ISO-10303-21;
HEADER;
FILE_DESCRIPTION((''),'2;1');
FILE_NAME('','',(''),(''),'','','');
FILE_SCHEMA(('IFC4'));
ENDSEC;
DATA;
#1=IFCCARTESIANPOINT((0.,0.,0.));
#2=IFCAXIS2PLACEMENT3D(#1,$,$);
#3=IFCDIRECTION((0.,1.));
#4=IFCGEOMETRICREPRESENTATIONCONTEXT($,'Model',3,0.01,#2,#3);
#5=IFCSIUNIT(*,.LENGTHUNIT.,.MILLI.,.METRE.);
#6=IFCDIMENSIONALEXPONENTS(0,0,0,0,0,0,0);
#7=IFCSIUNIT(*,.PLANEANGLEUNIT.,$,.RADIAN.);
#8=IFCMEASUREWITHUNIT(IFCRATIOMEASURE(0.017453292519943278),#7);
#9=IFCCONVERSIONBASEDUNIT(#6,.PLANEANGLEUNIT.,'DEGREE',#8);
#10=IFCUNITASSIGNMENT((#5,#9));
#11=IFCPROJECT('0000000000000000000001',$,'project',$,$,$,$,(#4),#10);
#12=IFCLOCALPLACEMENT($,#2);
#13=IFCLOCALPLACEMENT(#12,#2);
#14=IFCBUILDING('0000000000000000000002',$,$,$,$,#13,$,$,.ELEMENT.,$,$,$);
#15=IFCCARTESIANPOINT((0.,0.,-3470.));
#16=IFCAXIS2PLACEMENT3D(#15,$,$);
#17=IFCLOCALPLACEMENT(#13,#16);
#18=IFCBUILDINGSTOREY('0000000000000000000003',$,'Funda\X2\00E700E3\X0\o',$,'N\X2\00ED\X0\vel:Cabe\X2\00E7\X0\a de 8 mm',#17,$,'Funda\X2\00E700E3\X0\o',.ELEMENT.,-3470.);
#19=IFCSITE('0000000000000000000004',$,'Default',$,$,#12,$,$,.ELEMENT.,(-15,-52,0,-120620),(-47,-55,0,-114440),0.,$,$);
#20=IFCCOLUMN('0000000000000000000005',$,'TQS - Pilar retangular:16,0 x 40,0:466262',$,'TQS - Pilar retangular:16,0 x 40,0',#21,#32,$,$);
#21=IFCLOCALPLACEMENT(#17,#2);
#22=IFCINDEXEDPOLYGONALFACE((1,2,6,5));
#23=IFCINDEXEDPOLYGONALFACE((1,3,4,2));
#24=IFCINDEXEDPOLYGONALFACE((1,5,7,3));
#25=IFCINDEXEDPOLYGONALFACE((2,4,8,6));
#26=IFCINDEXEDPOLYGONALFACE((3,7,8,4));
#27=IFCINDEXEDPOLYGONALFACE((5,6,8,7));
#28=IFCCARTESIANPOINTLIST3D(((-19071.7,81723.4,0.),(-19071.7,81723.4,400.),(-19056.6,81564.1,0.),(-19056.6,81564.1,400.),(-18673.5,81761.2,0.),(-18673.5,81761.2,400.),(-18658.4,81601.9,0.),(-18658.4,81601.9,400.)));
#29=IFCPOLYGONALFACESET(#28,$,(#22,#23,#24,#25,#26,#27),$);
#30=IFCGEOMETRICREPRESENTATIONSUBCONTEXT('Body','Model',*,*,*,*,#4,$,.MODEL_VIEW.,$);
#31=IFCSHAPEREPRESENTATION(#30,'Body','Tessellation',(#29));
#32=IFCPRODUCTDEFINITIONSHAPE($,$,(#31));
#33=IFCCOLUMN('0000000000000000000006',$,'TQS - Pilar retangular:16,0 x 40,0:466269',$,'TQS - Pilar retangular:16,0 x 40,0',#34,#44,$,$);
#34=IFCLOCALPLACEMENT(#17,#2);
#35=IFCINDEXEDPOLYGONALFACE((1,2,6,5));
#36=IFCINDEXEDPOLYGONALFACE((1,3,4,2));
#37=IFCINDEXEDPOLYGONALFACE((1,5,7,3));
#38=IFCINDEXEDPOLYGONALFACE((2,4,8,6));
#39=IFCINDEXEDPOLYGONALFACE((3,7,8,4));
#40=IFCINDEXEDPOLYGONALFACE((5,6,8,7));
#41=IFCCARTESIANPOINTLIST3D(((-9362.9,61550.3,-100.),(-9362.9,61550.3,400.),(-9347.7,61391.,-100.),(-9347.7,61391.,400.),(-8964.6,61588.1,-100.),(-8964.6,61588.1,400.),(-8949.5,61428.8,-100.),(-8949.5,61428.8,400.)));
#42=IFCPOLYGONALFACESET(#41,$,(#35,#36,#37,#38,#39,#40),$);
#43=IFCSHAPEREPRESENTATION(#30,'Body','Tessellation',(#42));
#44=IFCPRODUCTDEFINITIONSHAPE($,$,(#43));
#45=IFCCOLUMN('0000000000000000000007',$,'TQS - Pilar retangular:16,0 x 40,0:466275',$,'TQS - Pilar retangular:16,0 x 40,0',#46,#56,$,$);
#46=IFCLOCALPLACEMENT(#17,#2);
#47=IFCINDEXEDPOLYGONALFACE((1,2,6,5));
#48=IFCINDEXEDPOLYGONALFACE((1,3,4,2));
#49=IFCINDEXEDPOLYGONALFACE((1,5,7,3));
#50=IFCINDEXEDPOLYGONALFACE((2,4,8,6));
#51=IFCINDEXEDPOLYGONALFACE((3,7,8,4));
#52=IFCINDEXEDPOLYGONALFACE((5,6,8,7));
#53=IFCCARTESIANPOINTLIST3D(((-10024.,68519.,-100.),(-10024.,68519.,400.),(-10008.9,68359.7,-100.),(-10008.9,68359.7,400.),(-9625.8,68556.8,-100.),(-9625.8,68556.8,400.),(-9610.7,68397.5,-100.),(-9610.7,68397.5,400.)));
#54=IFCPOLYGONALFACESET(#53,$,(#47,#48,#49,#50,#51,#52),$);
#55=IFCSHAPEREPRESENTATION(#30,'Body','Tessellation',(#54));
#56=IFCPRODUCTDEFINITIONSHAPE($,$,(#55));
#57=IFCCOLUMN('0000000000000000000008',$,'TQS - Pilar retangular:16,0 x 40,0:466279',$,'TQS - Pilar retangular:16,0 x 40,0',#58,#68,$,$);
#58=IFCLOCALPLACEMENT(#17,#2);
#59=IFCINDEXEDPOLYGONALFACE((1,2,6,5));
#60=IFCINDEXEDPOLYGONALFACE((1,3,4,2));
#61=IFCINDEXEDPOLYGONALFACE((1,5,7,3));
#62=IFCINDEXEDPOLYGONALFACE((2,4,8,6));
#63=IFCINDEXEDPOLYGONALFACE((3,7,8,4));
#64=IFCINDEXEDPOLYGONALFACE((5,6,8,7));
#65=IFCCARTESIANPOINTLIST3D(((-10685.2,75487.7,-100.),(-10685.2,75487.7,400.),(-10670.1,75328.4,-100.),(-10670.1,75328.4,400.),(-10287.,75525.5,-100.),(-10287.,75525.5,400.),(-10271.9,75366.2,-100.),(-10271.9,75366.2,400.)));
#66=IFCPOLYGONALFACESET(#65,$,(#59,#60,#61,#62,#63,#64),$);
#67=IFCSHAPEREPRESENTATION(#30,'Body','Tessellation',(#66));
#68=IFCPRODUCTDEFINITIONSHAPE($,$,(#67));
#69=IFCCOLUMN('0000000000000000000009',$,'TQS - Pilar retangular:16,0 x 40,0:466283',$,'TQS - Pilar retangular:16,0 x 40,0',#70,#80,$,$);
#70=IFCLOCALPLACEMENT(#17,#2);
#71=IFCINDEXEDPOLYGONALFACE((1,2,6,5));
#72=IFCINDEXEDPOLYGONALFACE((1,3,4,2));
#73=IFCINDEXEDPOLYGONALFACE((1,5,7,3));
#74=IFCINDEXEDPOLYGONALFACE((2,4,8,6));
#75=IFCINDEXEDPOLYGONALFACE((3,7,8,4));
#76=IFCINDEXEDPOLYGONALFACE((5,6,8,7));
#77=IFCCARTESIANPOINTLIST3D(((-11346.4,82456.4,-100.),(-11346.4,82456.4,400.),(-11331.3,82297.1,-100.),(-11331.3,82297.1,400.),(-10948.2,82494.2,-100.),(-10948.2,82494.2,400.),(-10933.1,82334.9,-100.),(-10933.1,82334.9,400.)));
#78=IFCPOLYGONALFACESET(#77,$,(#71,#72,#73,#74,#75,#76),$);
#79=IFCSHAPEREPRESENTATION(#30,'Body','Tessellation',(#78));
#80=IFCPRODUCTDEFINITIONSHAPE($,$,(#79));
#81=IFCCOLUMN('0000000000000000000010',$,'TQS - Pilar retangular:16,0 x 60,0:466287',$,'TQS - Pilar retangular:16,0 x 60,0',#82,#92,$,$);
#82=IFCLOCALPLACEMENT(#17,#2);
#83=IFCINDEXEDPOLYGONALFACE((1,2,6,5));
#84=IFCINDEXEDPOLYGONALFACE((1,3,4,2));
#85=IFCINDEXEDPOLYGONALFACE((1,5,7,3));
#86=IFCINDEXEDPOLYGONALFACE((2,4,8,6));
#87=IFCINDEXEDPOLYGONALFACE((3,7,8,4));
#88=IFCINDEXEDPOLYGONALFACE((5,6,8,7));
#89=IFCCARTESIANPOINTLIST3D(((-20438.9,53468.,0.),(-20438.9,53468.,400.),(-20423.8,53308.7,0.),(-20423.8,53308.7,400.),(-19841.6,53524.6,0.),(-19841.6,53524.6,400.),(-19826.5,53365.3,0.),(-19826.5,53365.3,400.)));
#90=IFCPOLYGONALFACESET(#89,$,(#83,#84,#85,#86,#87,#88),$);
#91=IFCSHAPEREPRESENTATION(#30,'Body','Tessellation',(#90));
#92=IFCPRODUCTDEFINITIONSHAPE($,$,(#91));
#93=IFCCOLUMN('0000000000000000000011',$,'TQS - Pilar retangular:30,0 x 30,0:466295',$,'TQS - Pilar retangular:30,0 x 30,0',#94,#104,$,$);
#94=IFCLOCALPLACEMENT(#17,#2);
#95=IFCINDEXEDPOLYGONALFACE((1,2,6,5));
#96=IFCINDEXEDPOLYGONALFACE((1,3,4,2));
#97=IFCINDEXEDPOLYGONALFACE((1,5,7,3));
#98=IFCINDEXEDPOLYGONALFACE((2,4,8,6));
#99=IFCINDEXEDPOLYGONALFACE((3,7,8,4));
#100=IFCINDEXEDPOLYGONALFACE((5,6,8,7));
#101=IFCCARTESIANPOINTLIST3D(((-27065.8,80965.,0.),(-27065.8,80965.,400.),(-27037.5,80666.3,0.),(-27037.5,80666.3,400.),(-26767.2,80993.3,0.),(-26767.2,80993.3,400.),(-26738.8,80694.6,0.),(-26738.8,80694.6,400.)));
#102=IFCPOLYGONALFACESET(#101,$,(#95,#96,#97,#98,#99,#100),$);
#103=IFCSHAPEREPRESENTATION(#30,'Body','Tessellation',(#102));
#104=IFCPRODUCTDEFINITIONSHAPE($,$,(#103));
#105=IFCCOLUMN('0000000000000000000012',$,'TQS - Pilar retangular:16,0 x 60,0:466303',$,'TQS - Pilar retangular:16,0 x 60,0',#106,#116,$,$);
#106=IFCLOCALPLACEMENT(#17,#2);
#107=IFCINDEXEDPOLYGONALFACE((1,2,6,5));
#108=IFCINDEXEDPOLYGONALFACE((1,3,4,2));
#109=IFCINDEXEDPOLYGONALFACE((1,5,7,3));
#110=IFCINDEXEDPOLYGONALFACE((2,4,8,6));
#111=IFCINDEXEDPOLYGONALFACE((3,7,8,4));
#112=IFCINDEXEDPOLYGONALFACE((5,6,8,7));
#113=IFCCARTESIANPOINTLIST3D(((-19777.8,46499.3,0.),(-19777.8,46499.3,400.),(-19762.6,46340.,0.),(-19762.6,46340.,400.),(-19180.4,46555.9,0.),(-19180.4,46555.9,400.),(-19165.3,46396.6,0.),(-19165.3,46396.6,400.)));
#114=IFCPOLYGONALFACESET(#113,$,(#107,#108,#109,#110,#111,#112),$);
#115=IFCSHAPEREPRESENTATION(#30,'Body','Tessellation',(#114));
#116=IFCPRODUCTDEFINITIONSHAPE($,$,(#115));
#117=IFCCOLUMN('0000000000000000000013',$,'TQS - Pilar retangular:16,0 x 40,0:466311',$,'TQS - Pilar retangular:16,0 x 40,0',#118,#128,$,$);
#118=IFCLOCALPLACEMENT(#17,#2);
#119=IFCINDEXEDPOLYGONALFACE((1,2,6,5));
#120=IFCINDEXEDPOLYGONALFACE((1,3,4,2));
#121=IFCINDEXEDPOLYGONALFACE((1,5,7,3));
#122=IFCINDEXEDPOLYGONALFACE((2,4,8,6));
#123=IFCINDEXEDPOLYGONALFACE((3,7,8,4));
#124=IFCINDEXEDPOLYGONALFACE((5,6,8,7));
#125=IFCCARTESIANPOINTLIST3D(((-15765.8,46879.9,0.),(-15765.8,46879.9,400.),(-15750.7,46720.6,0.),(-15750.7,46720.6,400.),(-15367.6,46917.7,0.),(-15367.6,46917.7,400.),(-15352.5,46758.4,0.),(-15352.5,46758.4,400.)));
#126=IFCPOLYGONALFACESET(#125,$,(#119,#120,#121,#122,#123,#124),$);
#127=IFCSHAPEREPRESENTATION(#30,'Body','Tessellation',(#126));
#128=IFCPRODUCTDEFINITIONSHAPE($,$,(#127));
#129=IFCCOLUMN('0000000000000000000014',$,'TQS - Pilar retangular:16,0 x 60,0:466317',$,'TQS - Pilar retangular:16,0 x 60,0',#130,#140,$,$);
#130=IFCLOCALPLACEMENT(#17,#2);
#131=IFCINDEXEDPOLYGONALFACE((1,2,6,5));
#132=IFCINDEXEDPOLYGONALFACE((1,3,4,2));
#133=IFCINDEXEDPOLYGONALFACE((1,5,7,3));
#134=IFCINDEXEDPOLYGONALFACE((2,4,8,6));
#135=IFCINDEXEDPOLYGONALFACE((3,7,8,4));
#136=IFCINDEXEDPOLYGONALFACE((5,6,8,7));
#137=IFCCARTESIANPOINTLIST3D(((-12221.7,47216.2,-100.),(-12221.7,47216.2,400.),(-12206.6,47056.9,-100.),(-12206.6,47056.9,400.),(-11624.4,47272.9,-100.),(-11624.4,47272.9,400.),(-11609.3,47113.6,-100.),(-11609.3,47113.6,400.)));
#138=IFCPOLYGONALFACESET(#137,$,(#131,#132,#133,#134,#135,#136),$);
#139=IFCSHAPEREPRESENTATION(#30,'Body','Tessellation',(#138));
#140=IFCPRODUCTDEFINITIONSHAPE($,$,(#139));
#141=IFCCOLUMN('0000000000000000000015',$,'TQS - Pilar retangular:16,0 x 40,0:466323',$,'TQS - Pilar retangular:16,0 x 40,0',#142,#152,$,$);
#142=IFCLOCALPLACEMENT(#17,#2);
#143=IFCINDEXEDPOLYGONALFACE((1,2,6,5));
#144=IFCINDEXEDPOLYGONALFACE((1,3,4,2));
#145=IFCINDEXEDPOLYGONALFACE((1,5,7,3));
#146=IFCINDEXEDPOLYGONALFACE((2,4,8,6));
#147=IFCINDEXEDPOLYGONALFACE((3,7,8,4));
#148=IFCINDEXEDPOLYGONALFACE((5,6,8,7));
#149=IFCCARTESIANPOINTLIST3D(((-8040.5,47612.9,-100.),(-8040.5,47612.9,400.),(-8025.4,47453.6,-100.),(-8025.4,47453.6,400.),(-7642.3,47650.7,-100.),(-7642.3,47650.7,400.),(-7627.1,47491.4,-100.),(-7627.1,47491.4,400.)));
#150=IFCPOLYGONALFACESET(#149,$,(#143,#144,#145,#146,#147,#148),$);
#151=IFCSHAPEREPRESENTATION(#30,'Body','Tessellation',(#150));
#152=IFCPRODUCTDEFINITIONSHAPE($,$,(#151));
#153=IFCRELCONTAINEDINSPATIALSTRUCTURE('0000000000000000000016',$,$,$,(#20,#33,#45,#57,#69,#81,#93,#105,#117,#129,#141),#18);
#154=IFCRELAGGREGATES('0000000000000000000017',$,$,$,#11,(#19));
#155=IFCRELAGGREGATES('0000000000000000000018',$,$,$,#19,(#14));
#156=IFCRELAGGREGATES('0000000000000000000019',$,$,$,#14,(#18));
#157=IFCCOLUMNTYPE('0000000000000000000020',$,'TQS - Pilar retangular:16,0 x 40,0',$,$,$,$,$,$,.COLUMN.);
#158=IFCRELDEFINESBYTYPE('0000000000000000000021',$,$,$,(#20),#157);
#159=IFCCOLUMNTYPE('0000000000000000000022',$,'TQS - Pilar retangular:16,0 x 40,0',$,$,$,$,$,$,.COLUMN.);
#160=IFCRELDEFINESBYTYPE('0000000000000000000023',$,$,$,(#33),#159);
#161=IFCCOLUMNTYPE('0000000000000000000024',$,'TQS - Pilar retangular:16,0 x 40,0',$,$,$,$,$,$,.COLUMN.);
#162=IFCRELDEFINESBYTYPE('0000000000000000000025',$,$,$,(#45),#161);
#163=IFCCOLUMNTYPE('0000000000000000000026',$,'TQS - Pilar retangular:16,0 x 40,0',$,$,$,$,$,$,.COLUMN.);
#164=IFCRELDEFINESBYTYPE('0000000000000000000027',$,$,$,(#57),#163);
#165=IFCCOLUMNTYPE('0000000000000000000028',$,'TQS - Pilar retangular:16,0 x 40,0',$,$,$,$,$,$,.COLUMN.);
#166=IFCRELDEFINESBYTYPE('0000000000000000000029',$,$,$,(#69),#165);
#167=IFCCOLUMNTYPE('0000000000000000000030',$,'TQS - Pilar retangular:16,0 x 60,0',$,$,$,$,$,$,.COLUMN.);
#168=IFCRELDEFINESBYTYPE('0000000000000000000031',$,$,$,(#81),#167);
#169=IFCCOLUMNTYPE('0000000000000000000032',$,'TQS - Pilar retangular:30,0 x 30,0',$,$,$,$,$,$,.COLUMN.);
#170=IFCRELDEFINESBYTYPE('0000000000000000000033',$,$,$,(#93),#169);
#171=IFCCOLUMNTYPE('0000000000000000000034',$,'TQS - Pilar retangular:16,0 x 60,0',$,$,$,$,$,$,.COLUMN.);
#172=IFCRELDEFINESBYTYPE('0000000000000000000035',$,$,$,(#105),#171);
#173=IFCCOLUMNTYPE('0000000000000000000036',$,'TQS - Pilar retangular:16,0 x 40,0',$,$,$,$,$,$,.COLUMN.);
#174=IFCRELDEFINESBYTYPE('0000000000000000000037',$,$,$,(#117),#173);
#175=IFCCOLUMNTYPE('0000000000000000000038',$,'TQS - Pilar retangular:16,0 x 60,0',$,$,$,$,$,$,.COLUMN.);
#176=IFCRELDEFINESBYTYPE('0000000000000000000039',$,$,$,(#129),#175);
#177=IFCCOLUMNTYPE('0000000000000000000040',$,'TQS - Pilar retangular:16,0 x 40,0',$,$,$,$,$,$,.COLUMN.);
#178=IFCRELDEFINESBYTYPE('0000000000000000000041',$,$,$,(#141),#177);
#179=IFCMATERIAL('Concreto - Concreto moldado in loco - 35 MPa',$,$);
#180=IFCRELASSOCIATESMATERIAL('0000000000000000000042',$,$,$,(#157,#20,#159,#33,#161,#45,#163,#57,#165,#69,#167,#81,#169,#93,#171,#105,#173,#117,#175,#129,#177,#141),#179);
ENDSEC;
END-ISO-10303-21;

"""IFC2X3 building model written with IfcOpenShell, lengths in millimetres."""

from ifc_helpers import new_model, entity, si_unit, converted_unit, direction, frame, frame_2d, origin, origin_2d_with_axis, place, context, subcontext, project, spatial, rectangle, extrude, source, transform, mapped, material, type_object, type_shapes, element, save


model = new_model("IFC2X3")

# Units and contexts
model_context = context("Model", 3, precision=0.01, world=origin(), true_north=direction((0.0, 1.0)))
body_context = subcontext(model_context, "Body", "Model", "MODEL_VIEW")
ifc_project = project(units=[si_unit("LENGTHUNIT", "METRE", prefix="MILLI"), converted_unit("PLANEANGLEUNIT", "DEGREE", entity("IfcRatioMeasure", 0.017453292519943278), si_unit("PLANEANGLEUNIT", "RADIAN"), dimensions=[0, 0, 0, 0, 0, 0, 0])], contexts=[model_context])

# Site, building, storey
site_placement = place(None, origin())
site = spatial("IfcSite", under=ifc_project, at=site_placement, Name="Default", CompositionType="ELEMENT", RefLatitude=(-15, -52, 0, -120620), RefLongitude=(-47, -55, 0, -114440), RefElevation=0.0)
building_placement = place(site_placement, origin())
building = spatial("IfcBuilding", under=site, at=building_placement, CompositionType="ELEMENT")
storey_placement = place(building_placement, frame((0.0, 0.0, -3470.0)))
storey = spatial("IfcBuildingStorey", under=building, at=storey_placement, Name="Fundação", ObjectType="Nível:Cabeça de 8 mm", LongName="Fundação", CompositionType="ELEMENT", Elevation=-3470.0)

# Columns
ifc_material_1 = material(Name="Concreto - Concreto moldado in loco - 35 MPa")
column_type_1 = type_object("IfcColumnType", Name="TQS - Pilar retangular:16,0 x 40,0", PredefinedType="COLUMN", material=ifc_material_1)
shared_shape_1 = source(origin(), body_context, "Body", "SweptSolid", [
    extrude(rectangle(XDim=400.0, YDim=160.0, at=origin_2d_with_axis()), frame((-18865.1, 81662.7, -3470.0), z_axis=(0.0, 0.0, 1.0), x_axis=(-0.995529, -0.094456, 0.0)), (0.0, 0.0, 1.0), 400.0),
])
type_shapes(column_type_1, [shared_shape_1])
column_1_placement = place(storey_placement, frame((0.0, 0.0, 3470.0)))
element("IfcColumn", 1, at=column_1_placement, inside=storey, type_object=column_type_1, material=ifc_material_1, Name="TQS - Pilar retangular:16,0 x 40,0:466262", ObjectType="TQS - Pilar retangular:16,0 x 40,0", context=body_context, shape_type="MappedRepresentation", body=[
    mapped(shared_shape_1, transform((0.0, 0.0, 0.0), scale=1.0)),
])
column_type_2 = type_object("IfcColumnType", Name="TQS - Pilar retangular:16,0 x 40,0", PredefinedType="COLUMN", material=ifc_material_1)
shared_shape_2 = source(origin(), body_context, "Body", "SweptSolid", [
    extrude(rectangle(XDim=400.0, YDim=160.0, at=origin_2d_with_axis()), frame((-9156.2, 61489.5, -3570.0), z_axis=(0.0, 0.0, 1.0), x_axis=(-0.995529, -0.094456, 0.0)), (0.0, 0.0, 1.0), 500.0),
])
type_shapes(column_type_2, [shared_shape_2])
column_2_placement = place(storey_placement, frame((0.0, 0.0, 3470.0)))
element("IfcColumn", 2, at=column_2_placement, inside=storey, type_object=column_type_2, material=ifc_material_1, Name="TQS - Pilar retangular:16,0 x 40,0:466269", ObjectType="TQS - Pilar retangular:16,0 x 40,0", context=body_context, shape_type="MappedRepresentation", body=[
    mapped(shared_shape_2, transform((0.0, 0.0, 0.0), scale=1.0)),
])
column_type_3 = type_object("IfcColumnType", Name="TQS - Pilar retangular:16,0 x 40,0", PredefinedType="COLUMN", material=ifc_material_1)
shared_shape_3 = source(origin(), body_context, "Body", "SweptSolid", [
    extrude(rectangle(XDim=400.0, YDim=160.0, at=frame_2d((0.0, 0.0), x_axis=(1.0, 0.0))), frame((-9817.4, 68458.3, -3570.0), z_axis=(0.0, 0.0, 1.0), x_axis=(-0.995529, -0.094456, 0.0)), (0.0, 0.0, 1.0), 500.0),
])
type_shapes(column_type_3, [shared_shape_3])
column_3_placement = place(storey_placement, frame((0.0, 0.0, 3470.0)))
element("IfcColumn", 3, at=column_3_placement, inside=storey, type_object=column_type_3, material=ifc_material_1, Name="TQS - Pilar retangular:16,0 x 40,0:466275", ObjectType="TQS - Pilar retangular:16,0 x 40,0", context=body_context, shape_type="MappedRepresentation", body=[
    mapped(shared_shape_3, transform((0.0, 0.0, 0.0), scale=1.0)),
])
column_type_4 = type_object("IfcColumnType", Name="TQS - Pilar retangular:16,0 x 40,0", PredefinedType="COLUMN", material=ifc_material_1)
shared_shape_4 = source(origin(), body_context, "Body", "SweptSolid", [
    extrude(rectangle(XDim=400.0, YDim=160.0, at=origin_2d_with_axis()), frame((-10478.6, 75427.0, -3570.0), z_axis=(0.0, 0.0, 1.0), x_axis=(-0.995529, -0.094456, 0.0)), (0.0, 0.0, 1.0), 500.0),
])
type_shapes(column_type_4, [shared_shape_4])
column_4_placement = place(storey_placement, frame((0.0, 0.0, 3470.0)))
element("IfcColumn", 4, at=column_4_placement, inside=storey, type_object=column_type_4, material=ifc_material_1, Name="TQS - Pilar retangular:16,0 x 40,0:466279", ObjectType="TQS - Pilar retangular:16,0 x 40,0", context=body_context, shape_type="MappedRepresentation", body=[
    mapped(shared_shape_4, transform((0.0, 0.0, 0.0), scale=1.0)),
])
column_type_5 = type_object("IfcColumnType", Name="TQS - Pilar retangular:16,0 x 40,0", PredefinedType="COLUMN", material=ifc_material_1)
shared_shape_5 = source(origin(), body_context, "Body", "SweptSolid", [
    extrude(rectangle(XDim=400.0, YDim=160.0, at=origin_2d_with_axis()), frame((-11139.8, 82395.7, -3570.0), z_axis=(0.0, 0.0, 1.0), x_axis=(-0.995529, -0.094456, 0.0)), (0.0, 0.0, 1.0), 500.0),
])
type_shapes(column_type_5, [shared_shape_5])
column_5_placement = place(storey_placement, frame((0.0, 0.0, 3470.0)))
element("IfcColumn", 5, at=column_5_placement, inside=storey, type_object=column_type_5, material=ifc_material_1, Name="TQS - Pilar retangular:16,0 x 40,0:466283", ObjectType="TQS - Pilar retangular:16,0 x 40,0", context=body_context, shape_type="MappedRepresentation", body=[
    mapped(shared_shape_5, transform((0.0, 0.0, 0.0), scale=1.0)),
])
column_type_6 = type_object("IfcColumnType", Name="TQS - Pilar retangular:16,0 x 60,0", PredefinedType="COLUMN", material=ifc_material_1)
shared_shape_6 = source(origin(), body_context, "Body", "SweptSolid", [
    extrude(rectangle(XDim=600.0, YDim=160.0, at=origin_2d_with_axis()), frame((-20132.7, 53416.7, -3470.0), z_axis=(0.0, 0.0, 1.0), x_axis=(-0.995529, -0.094456, 0.0)), (0.0, 0.0, 1.0), 400.0),
])
type_shapes(column_type_6, [shared_shape_6])
column_6_placement = place(storey_placement, frame((0.0, 0.0, 3470.0)))
element("IfcColumn", 6, at=column_6_placement, inside=storey, type_object=column_type_6, material=ifc_material_1, Name="TQS - Pilar retangular:16,0 x 60,0:466287", ObjectType="TQS - Pilar retangular:16,0 x 60,0", context=body_context, shape_type="MappedRepresentation", body=[
    mapped(shared_shape_6, transform((0.0, 0.0, 0.0), scale=1.0)),
])
column_type_7 = type_object("IfcColumnType", Name="TQS - Pilar retangular:30,0 x 30,0", PredefinedType="COLUMN", material=ifc_material_1)
shared_shape_7 = source(origin(), body_context, "Body", "SweptSolid", [
    extrude(rectangle(XDim=300.0, YDim=300.0, at=origin_2d_with_axis()), frame((-26902.3, 80829.8, -3470.0), z_axis=(0.0, 0.0, 1.0), x_axis=(-0.995529, -0.094456, 0.0)), (0.0, 0.0, 1.0), 400.0),
])
type_shapes(column_type_7, [shared_shape_7])
column_7_placement = place(storey_placement, frame((0.0, 0.0, 3470.0)))
element("IfcColumn", 7, at=column_7_placement, inside=storey, type_object=column_type_7, material=ifc_material_1, Name="TQS - Pilar retangular:30,0 x 30,0:466295", ObjectType="TQS - Pilar retangular:30,0 x 30,0", context=body_context, shape_type="MappedRepresentation", body=[
    mapped(shared_shape_7, transform((0.0, 0.0, 0.0), scale=1.0)),
])
column_type_8 = type_object("IfcColumnType", Name="TQS - Pilar retangular:16,0 x 60,0", PredefinedType="COLUMN", material=ifc_material_1)
shared_shape_8 = source(origin(), body_context, "Body", "SweptSolid", [
    extrude(rectangle(XDim=600.0, YDim=160.0, at=origin_2d_with_axis()), frame((-19471.5, 46448.0, -3470.0), z_axis=(0.0, 0.0, 1.0), x_axis=(-0.995529, -0.094456, 0.0)), (0.0, 0.0, 1.0), 400.0),
])
type_shapes(column_type_8, [shared_shape_8])
column_8_placement = place(storey_placement, frame((0.0, 0.0, 3470.0)))
element("IfcColumn", 8, at=column_8_placement, inside=storey, type_object=column_type_8, material=ifc_material_1, Name="TQS - Pilar retangular:16,0 x 60,0:466303", ObjectType="TQS - Pilar retangular:16,0 x 60,0", context=body_context, shape_type="MappedRepresentation", body=[
    mapped(shared_shape_8, transform((0.0, 0.0, 0.0), scale=1.0)),
])
column_type_9 = type_object("IfcColumnType", Name="TQS - Pilar retangular:16,0 x 40,0", PredefinedType="COLUMN", material=ifc_material_1)
shared_shape_9 = source(origin(), body_context, "Body", "SweptSolid", [
    extrude(rectangle(XDim=400.0, YDim=160.0, at=frame_2d((0.0, 0.0), x_axis=(1.0, 0.0))), frame((-15559.1, 46819.2, -3470.0), z_axis=(0.0, 0.0, 1.0), x_axis=(-0.995529, -0.094456, 0.0)), (0.0, 0.0, 1.0), 400.0),
])
type_shapes(column_type_9, [shared_shape_9])
column_9_placement = place(storey_placement, frame((0.0, 0.0, 3470.0)))
element("IfcColumn", 9, at=column_9_placement, inside=storey, type_object=column_type_9, material=ifc_material_1, Name="TQS - Pilar retangular:16,0 x 40,0:466311", ObjectType="TQS - Pilar retangular:16,0 x 40,0", context=body_context, shape_type="MappedRepresentation", body=[
    mapped(shared_shape_9, transform((0.0, 0.0, 0.0), scale=1.0)),
])
column_type_10 = type_object("IfcColumnType", Name="TQS - Pilar retangular:16,0 x 60,0", PredefinedType="COLUMN", material=ifc_material_1)
shared_shape_10 = source(origin(), body_context, "Body", "SweptSolid", [
    extrude(rectangle(XDim=600.0, YDim=160.0, at=frame_2d((0.0, 0.0), x_axis=(1.0, 0.0))), frame((-11915.5, 47164.9, -3570.0), z_axis=(0.0, 0.0, 1.0), x_axis=(-0.995529, -0.094456, 0.0)), (0.0, 0.0, 1.0), 500.0),
])
type_shapes(column_type_10, [shared_shape_10])
column_10_placement = place(storey_placement, frame((0.0, 0.0, 3470.0)))
element("IfcColumn", 10, at=column_10_placement, inside=storey, type_object=column_type_10, material=ifc_material_1, Name="TQS - Pilar retangular:16,0 x 60,0:466317", ObjectType="TQS - Pilar retangular:16,0 x 60,0", context=body_context, shape_type="MappedRepresentation", body=[
    mapped(shared_shape_10, transform((0.0, 0.0, 0.0), scale=1.0)),
])
column_type_11 = type_object("IfcColumnType", Name="TQS - Pilar retangular:16,0 x 40,0", PredefinedType="COLUMN", material=ifc_material_1)
shared_shape_11 = source(origin(), body_context, "Body", "SweptSolid", [
    extrude(rectangle(XDim=400.0, YDim=160.0, at=origin_2d_with_axis()), frame((-7833.8, 47552.1, -3570.0), z_axis=(0.0, 0.0, 1.0), x_axis=(-0.995529, -0.094456, 0.0)), (0.0, 0.0, 1.0), 500.0),
])
type_shapes(column_type_11, [shared_shape_11])
column_11_placement = place(storey_placement, frame((0.0, 0.0, 3470.0)))
element("IfcColumn", 11, at=column_11_placement, inside=storey, type_object=column_type_11, material=ifc_material_1, Name="TQS - Pilar retangular:16,0 x 40,0:466323", ObjectType="TQS - Pilar retangular:16,0 x 40,0", context=body_context, shape_type="MappedRepresentation", body=[
    mapped(shared_shape_11, transform((0.0, 0.0, 0.0), scale=1.0)),
])

save(model, "model.ifc")
